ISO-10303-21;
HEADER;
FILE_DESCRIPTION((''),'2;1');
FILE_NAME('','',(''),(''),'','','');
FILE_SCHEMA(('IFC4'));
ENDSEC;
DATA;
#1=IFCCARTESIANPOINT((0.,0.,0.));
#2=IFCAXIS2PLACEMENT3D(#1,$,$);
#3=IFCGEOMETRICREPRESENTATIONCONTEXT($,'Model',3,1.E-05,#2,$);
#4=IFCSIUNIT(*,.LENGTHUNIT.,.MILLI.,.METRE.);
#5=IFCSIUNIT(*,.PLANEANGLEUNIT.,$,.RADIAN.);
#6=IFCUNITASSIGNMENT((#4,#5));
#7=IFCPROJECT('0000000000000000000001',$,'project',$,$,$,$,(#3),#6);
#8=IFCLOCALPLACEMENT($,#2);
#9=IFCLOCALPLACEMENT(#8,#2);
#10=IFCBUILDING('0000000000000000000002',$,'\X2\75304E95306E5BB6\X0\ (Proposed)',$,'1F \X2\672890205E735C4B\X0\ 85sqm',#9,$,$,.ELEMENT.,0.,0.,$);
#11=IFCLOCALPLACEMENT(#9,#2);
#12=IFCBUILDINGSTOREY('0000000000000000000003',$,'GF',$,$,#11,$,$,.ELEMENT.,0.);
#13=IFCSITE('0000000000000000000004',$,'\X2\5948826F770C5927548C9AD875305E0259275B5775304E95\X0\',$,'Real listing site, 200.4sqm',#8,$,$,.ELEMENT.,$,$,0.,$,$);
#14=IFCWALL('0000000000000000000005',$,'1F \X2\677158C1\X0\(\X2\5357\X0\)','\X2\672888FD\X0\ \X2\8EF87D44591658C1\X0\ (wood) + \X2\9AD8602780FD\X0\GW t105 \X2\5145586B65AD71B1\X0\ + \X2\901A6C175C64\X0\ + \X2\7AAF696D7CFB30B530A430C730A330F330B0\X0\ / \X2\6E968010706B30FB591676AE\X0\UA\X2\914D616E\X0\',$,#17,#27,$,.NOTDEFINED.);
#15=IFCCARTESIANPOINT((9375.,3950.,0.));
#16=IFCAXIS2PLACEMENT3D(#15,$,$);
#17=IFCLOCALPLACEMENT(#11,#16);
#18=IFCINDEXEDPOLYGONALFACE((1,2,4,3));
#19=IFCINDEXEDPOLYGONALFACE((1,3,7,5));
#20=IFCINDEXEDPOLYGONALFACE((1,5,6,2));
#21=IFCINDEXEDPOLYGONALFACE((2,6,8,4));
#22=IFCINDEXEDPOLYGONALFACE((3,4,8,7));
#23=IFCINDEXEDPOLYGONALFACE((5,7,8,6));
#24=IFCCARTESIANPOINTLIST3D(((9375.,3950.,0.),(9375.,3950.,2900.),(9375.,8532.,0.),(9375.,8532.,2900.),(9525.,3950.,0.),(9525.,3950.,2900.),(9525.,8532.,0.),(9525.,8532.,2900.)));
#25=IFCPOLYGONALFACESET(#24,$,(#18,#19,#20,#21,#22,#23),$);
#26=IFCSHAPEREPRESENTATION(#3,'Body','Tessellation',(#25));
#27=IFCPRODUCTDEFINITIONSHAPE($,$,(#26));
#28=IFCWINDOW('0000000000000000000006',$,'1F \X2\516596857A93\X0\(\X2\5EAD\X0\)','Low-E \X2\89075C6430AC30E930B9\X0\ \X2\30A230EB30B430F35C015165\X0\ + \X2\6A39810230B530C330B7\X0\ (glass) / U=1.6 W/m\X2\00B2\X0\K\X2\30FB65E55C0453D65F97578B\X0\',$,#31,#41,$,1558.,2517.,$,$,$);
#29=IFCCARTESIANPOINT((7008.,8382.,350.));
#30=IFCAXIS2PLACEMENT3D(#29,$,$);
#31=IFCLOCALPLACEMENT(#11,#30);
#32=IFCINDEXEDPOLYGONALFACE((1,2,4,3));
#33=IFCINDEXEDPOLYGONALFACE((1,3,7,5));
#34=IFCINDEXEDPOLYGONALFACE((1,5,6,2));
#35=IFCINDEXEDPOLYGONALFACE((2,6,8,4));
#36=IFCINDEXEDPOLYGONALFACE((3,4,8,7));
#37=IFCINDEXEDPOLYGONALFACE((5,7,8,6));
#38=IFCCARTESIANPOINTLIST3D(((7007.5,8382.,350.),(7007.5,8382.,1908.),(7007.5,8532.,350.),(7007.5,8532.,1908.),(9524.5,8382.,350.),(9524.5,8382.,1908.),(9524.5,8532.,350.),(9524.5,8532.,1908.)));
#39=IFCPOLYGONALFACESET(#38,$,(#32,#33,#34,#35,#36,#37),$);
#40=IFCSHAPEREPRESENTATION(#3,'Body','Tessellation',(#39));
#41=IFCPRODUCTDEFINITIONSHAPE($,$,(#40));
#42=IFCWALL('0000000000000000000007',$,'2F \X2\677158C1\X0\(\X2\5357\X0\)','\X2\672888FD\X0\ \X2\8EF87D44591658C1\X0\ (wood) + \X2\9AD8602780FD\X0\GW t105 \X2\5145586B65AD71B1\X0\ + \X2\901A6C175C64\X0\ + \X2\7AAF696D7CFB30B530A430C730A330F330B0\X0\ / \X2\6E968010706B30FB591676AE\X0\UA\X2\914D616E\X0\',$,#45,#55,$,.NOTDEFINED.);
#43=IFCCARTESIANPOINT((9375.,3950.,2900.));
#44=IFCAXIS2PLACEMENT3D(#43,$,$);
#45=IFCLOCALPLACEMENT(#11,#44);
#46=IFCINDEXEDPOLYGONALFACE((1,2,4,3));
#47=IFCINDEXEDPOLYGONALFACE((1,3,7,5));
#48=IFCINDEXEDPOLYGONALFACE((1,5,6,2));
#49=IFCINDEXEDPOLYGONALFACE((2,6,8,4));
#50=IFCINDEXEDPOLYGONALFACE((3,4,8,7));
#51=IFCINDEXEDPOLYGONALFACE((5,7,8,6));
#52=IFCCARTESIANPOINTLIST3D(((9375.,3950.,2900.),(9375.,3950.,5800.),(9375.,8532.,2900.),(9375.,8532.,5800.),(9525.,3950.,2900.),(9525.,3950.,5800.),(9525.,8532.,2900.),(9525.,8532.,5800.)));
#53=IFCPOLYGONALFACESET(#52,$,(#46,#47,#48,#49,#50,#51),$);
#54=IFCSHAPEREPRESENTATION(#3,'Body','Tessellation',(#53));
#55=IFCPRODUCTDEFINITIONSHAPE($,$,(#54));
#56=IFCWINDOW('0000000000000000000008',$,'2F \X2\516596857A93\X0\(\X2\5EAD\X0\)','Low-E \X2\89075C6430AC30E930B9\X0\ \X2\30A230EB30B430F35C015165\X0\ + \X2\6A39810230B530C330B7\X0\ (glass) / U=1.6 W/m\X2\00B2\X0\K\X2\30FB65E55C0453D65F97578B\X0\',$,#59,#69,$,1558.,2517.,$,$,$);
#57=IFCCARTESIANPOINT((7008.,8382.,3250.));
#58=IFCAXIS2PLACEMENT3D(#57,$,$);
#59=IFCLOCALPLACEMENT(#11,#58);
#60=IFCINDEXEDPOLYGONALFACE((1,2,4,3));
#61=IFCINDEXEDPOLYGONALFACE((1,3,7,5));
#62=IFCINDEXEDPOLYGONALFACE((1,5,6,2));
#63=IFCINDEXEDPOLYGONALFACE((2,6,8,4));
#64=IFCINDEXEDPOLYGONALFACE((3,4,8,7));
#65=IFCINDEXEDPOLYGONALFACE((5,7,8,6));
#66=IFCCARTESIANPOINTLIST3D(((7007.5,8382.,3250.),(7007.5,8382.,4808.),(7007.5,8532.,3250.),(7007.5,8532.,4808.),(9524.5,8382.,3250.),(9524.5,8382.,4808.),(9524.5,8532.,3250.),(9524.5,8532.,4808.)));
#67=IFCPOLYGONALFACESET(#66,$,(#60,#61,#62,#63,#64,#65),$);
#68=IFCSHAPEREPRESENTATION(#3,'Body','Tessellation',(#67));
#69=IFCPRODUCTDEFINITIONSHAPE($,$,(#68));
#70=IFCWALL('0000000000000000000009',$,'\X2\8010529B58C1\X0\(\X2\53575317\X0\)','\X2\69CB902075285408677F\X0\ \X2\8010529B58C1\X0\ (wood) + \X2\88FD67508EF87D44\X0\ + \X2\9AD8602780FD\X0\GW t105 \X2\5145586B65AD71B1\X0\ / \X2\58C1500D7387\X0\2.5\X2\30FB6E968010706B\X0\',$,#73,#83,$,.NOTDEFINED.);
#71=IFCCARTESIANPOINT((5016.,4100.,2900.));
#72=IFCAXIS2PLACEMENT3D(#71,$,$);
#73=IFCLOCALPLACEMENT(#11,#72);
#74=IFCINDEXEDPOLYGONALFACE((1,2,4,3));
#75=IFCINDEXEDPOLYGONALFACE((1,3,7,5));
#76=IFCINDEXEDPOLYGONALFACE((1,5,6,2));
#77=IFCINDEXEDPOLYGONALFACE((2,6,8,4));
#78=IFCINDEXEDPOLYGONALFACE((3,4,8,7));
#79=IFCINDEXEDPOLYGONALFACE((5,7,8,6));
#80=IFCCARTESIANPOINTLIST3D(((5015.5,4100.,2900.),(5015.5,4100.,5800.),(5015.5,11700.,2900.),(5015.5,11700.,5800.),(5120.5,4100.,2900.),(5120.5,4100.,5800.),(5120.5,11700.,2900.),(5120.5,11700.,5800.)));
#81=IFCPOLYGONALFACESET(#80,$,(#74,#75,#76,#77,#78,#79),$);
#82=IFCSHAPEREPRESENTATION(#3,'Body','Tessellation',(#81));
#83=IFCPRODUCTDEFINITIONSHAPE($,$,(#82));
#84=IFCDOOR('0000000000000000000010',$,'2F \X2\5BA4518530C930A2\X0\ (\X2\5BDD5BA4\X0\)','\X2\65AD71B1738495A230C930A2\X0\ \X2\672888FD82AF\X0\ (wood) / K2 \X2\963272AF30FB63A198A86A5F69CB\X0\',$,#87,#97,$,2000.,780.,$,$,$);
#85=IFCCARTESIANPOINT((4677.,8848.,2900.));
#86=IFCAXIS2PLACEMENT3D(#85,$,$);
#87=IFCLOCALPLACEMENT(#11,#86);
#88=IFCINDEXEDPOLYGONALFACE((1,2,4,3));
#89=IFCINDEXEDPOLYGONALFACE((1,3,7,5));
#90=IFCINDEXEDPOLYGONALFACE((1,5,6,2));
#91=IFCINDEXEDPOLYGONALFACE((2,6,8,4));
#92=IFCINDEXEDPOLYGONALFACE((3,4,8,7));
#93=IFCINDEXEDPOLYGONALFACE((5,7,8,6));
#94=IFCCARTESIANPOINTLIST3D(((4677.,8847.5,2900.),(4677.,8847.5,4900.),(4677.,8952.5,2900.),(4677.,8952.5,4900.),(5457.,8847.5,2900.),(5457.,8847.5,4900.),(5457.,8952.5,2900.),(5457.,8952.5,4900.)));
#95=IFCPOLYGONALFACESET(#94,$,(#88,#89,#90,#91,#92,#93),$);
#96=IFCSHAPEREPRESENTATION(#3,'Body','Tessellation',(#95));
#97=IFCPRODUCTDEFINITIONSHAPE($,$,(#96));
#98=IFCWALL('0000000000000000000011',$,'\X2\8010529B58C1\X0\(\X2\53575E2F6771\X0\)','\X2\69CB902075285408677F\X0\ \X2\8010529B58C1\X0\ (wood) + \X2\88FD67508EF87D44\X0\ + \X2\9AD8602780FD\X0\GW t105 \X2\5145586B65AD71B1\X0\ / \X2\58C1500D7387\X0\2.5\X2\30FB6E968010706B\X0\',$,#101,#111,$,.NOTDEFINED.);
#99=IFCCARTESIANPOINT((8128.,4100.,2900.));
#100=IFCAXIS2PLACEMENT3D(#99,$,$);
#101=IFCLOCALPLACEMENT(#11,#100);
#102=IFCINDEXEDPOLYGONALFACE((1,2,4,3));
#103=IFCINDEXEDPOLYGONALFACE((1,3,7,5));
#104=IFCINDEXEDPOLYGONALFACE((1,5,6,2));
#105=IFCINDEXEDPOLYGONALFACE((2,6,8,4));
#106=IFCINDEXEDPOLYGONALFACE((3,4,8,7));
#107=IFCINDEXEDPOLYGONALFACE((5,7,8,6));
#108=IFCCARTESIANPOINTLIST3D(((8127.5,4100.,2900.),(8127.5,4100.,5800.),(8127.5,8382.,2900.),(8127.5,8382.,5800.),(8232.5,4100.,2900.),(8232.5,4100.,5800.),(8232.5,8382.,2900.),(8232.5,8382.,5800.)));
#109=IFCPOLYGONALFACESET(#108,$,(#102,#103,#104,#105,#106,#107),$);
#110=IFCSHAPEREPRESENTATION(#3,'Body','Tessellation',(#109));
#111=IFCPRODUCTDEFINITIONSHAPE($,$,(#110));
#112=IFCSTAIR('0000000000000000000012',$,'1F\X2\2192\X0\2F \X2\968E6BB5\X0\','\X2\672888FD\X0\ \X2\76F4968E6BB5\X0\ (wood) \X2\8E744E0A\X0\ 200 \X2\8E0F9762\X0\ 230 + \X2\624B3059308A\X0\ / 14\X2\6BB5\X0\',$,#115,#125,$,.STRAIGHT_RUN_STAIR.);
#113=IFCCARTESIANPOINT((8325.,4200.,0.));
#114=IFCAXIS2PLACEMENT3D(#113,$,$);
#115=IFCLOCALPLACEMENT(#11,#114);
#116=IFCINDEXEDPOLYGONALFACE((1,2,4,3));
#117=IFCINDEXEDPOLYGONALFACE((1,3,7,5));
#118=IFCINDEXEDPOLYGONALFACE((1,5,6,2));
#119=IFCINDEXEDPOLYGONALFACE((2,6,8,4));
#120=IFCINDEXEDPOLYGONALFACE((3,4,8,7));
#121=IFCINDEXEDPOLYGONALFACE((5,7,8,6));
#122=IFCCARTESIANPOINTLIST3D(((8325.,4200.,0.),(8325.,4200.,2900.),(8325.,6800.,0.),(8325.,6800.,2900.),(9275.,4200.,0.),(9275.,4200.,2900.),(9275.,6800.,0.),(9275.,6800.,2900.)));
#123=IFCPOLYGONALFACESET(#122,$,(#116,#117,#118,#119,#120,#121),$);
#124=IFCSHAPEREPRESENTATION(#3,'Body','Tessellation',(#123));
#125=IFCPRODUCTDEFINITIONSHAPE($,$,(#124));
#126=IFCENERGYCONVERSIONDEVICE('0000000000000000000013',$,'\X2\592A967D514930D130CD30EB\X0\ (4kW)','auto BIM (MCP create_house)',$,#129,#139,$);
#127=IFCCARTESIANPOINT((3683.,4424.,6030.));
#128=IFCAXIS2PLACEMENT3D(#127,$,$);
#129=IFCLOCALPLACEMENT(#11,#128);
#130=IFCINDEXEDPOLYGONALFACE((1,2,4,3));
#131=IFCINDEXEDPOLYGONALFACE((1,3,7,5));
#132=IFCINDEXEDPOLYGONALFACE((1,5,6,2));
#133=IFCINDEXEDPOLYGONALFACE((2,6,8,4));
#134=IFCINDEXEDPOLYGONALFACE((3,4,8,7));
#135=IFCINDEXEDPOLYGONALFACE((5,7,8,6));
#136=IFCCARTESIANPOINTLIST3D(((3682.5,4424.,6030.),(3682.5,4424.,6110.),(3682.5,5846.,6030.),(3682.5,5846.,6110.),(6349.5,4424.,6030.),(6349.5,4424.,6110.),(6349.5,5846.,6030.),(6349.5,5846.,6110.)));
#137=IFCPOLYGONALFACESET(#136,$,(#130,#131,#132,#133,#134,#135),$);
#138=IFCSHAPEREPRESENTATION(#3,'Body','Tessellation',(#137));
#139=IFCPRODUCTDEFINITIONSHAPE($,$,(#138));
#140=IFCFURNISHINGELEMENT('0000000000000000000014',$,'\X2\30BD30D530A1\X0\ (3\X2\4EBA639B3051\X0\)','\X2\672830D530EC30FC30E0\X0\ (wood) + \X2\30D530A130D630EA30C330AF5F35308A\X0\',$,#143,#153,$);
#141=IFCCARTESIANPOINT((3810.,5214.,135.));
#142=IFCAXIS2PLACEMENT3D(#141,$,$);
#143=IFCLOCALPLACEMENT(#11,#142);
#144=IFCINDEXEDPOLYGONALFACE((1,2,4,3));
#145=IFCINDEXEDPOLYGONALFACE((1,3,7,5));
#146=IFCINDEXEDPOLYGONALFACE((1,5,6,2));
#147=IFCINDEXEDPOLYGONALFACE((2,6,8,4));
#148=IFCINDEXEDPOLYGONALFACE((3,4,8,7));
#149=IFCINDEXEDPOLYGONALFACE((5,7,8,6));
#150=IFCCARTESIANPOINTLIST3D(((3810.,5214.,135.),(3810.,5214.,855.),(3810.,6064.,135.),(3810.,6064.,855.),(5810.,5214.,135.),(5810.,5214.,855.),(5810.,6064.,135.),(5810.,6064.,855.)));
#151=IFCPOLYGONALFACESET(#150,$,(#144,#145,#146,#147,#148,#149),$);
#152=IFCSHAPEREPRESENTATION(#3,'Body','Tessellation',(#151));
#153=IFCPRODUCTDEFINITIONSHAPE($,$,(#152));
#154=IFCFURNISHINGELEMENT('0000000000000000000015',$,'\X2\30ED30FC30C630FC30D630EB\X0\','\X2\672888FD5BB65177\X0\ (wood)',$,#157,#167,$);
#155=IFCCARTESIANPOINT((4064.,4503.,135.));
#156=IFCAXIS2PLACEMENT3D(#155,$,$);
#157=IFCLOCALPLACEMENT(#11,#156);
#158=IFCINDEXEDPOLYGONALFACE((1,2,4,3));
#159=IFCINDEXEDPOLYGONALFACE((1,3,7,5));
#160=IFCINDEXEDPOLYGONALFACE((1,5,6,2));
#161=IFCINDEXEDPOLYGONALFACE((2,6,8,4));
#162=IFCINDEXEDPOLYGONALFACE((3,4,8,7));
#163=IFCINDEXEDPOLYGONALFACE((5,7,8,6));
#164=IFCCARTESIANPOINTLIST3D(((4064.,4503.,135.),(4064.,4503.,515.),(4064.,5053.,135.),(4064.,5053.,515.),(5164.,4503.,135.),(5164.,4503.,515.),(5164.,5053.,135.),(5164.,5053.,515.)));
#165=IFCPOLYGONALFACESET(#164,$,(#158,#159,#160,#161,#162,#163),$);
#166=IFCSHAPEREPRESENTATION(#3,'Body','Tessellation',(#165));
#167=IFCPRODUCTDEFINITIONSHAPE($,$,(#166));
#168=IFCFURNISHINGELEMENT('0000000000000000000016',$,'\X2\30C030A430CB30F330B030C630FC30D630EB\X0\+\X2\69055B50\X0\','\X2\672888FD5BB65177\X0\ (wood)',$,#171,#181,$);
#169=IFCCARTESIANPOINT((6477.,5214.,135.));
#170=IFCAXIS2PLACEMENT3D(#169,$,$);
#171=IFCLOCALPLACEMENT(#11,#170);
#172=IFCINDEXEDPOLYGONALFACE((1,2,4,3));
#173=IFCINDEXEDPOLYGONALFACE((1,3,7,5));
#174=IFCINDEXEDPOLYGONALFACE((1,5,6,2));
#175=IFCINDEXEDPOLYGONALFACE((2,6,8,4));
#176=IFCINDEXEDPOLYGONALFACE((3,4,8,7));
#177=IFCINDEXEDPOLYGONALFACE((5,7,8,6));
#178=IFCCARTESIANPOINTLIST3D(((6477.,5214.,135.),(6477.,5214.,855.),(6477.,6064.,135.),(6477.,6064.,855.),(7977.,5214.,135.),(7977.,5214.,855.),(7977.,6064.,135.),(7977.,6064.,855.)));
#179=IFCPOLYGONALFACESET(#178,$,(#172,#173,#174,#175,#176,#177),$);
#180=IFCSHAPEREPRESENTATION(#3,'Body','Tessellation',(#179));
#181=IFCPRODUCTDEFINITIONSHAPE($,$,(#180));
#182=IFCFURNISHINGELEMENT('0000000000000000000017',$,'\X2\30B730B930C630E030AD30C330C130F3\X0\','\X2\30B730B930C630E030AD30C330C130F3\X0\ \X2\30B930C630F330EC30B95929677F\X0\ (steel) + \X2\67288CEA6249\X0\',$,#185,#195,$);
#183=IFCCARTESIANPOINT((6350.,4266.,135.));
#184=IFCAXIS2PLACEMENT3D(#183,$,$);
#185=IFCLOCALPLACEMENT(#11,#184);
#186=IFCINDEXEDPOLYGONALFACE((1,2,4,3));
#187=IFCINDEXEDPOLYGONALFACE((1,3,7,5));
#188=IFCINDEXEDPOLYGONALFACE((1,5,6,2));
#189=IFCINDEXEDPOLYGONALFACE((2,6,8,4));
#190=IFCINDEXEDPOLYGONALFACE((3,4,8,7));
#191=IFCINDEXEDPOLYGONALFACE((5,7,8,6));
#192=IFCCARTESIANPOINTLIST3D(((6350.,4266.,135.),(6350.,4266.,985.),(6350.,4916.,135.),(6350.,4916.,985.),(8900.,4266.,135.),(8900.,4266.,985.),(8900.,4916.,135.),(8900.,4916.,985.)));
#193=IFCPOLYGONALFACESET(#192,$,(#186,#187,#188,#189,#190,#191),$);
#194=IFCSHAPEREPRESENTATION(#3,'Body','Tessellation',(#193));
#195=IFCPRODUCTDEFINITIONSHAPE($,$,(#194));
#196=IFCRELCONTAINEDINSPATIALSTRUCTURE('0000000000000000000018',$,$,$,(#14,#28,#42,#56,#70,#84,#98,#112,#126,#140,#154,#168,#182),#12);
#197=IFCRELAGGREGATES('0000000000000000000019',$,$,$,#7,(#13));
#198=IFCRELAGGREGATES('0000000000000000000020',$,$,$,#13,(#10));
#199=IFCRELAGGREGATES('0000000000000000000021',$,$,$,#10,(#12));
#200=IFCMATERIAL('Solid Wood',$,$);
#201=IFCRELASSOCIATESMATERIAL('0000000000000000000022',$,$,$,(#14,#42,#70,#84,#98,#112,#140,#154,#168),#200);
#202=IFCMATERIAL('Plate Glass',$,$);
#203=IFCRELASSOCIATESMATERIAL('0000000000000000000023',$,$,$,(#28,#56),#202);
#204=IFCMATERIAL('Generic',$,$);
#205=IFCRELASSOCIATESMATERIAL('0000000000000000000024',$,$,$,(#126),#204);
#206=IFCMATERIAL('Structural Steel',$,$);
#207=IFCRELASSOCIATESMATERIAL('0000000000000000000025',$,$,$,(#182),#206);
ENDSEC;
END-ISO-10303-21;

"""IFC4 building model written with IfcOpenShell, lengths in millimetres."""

from ifc_helpers import new_model, si_unit, frame, frame_2d, origin, place, context, project, spatial, rectangle, extrude, material, element, fill, save


model = new_model("IFC4")

# Units and contexts
model_context = context("Model", 3, precision=1e-05, world=origin())
ifc_project = project(units=[si_unit("LENGTHUNIT", "METRE", prefix="MILLI"), si_unit("PLANEANGLEUNIT", "RADIAN")], contexts=[model_context])

# Site, building, storey
site_placement = place(None, origin())
site = spatial("IfcSite", under=ifc_project, at=site_placement, Name="奈良県大和高田市大字田井", ObjectType="Real listing site, 200.4sqm", CompositionType="ELEMENT", RefElevation=0.0)
building_placement = place(site_placement, origin())
building = spatial("IfcBuilding", under=site, at=building_placement, Name="田井の家 (Proposed)", ObjectType="1F 木造平屋 85sqm", CompositionType="ELEMENT", ElevationOfRefHeight=0.0, ElevationOfTerrain=0.0)
storey_placement = place(building_placement, origin())
storey = spatial("IfcBuildingStorey", under=building, at=storey_placement, Name="GF", CompositionType="ELEMENT", Elevation=0.0)

# Wall, opening, window
ifc_material_1 = material(Name="Solid Wood")
wall_1_placement = place(storey_placement, frame((9375.0, 3950.0, 0.0)))
wall_1 = element("IfcWall", 1, at=wall_1_placement, inside=storey, material=ifc_material_1, Name="1F 東壁(南)", Description="木製 軸組外壁 (wood) + 高性能GW t105 充填断熱 + 通気層 + 窯業系サイディング / 準耐火・外皮UA配慮", PredefinedType="NOTDEFINED", context=model_context, shape_type="SweptSolid", body=[
    extrude(rectangle(XDim=150.0, YDim=4582.0, at=frame_2d((75.0, 2291.0))), frame((9375.0, 3950.0, 0.0)), (0.0, 0.0, 1.0), 2900.0),
])
opening_1_placement = place(storey_placement, frame((7008.0, 8382.0, 350.0)))
opening_1 = element("IfcOpeningElement", 2, at=opening_1_placement, cuts=wall_1, PredefinedType="NOTDEFINED", context=model_context, shape_type="SweptSolid", body=[
    extrude(rectangle(XDim=2517.0, YDim=150.0, at=frame_2d((1258.0, 75.0))), frame((7008.0, 8382.0, 350.0)), (0.0, 0.0, 1.0), 1558.0),
])
ifc_material_2 = material(Name="Plate Glass")
window_1_placement = place(storey_placement, frame((7008.0, 8382.0, 350.0)))
window_1 = element("IfcWindow", 3, at=window_1_placement, inside=storey, material=ifc_material_2, Name="1F 入隅窓(庭)", Description="Low-E 複層ガラス アルゴン封入 + 樹脂サッシ (glass) / U=1.6 W/m²K・日射取得型", OverallHeight=1558.0, OverallWidth=2517.0, context=model_context, shape_type="SweptSolid", body=[
    extrude(rectangle(XDim=2517.0, YDim=150.0, at=frame_2d((1258.0, 75.0))), frame((7008.0, 8382.0, 350.0)), (0.0, 0.0, 1.0), 1558.0),
])
fill(opening_1, window_1)

# Wall, opening, window
wall_2_placement = place(storey_placement, frame((9375.0, 3950.0, 2900.0)))
wall_2 = element("IfcWall", 4, at=wall_2_placement, inside=storey, material=ifc_material_1, Name="2F 東壁(南)", Description="木製 軸組外壁 (wood) + 高性能GW t105 充填断熱 + 通気層 + 窯業系サイディング / 準耐火・外皮UA配慮", PredefinedType="NOTDEFINED", context=model_context, shape_type="SweptSolid", body=[
    extrude(rectangle(XDim=150.0, YDim=4582.0, at=frame_2d((75.0, 2291.0))), frame((9375.0, 3950.0, 2900.0)), (0.0, 0.0, 1.0), 2900.0),
])
opening_2_placement = place(storey_placement, frame((7008.0, 8382.0, 3250.0)))
opening_2 = element("IfcOpeningElement", 5, at=opening_2_placement, cuts=wall_2, PredefinedType="NOTDEFINED", context=model_context, shape_type="SweptSolid", body=[
    extrude(rectangle(XDim=2517.0, YDim=150.0, at=frame_2d((1258.0, 75.0))), frame((7008.0, 8382.0, 3250.0)), (0.0, 0.0, 1.0), 1558.0),
])
window_2_placement = place(storey_placement, frame((7008.0, 8382.0, 3250.0)))
window_2 = element("IfcWindow", 6, at=window_2_placement, inside=storey, material=ifc_material_2, Name="2F 入隅窓(庭)", Description="Low-E 複層ガラス アルゴン封入 + 樹脂サッシ (glass) / U=1.6 W/m²K・日射取得型", OverallHeight=1558.0, OverallWidth=2517.0, context=model_context, shape_type="SweptSolid", body=[
    extrude(rectangle(XDim=2517.0, YDim=150.0, at=frame_2d((1258.0, 75.0))), frame((7008.0, 8382.0, 3250.0)), (0.0, 0.0, 1.0), 1558.0),
])
fill(opening_2, window_2)

# Wall, opening, door
wall_3_placement = place(storey_placement, frame((5016.0, 4100.0, 2900.0)))
wall_3 = element("IfcWall", 7, at=wall_3_placement, inside=storey, material=ifc_material_1, Name="耐力壁(南北)", Description="構造用合板 耐力壁 (wood) + 製材軸組 + 高性能GW t105 充填断熱 / 壁倍率2.5・準耐火", PredefinedType="NOTDEFINED", context=model_context, shape_type="SweptSolid", body=[
    extrude(rectangle(XDim=105.0, YDim=7600.0, at=frame_2d((52.0, 3800.0))), frame((5016.0, 4100.0, 2900.0)), (0.0, 0.0, 1.0), 2900.0),
])
opening_3_placement = place(storey_placement, frame((4677.0, 8848.0, 2900.0)))
opening_3 = element("IfcOpeningElement", 8, at=opening_3_placement, cuts=wall_3, PredefinedType="NOTDEFINED", context=model_context, shape_type="SweptSolid", body=[
    extrude(rectangle(XDim=780.0, YDim=105.0, at=frame_2d((390.0, 52.0))), frame((4677.0, 8848.0, 2900.0)), (0.0, 0.0, 1.0), 2000.0),
])
door_1_placement = place(storey_placement, frame((4677.0, 8848.0, 2900.0)))
door_1 = element("IfcDoor", 9, at=door_1_placement, inside=storey, material=ifc_material_1, Name="2F 室内ドア (寝室)", Description="断熱玄関ドア 木製芯 (wood) / K2 防犯・採風機構", OverallHeight=2000.0, OverallWidth=780.0, context=model_context, shape_type="SweptSolid", body=[
    extrude(rectangle(XDim=780.0, YDim=105.0, at=frame_2d((390.0, 52.0))), frame((4677.0, 8848.0, 2900.0)), (0.0, 0.0, 1.0), 2000.0),
])
fill(opening_3, door_1)

# Wall
wall_4_placement = place(storey_placement, frame((8128.0, 4100.0, 2900.0)))
element("IfcWall", 10, at=wall_4_placement, inside=storey, material=ifc_material_1, Name="耐力壁(南帯東)", Description="構造用合板 耐力壁 (wood) + 製材軸組 + 高性能GW t105 充填断熱 / 壁倍率2.5・準耐火", PredefinedType="NOTDEFINED", context=model_context, shape_type="SweptSolid", body=[
    extrude(rectangle(XDim=105.0, YDim=4282.0, at=frame_2d((52.0, 2141.0))), frame((8128.0, 4100.0, 2900.0)), (0.0, 0.0, 1.0), 2900.0),
])

# Stair
stair_placement = place(storey_placement, frame((8325.0, 4200.0, 0.0)))
element("IfcStair", 11, at=stair_placement, inside=storey, material=ifc_material_1, Name="1F→2F 階段", Description="木製 直階段 (wood) 蹴上 200 踏面 230 + 手すり / 14段", PredefinedType="STRAIGHT_RUN_STAIR", context=model_context, shape_type="SweptSolid", body=[
    extrude(rectangle(XDim=950.0, YDim=2600.0, at=frame_2d((475.0, 1300.0))), frame((8325.0, 4200.0, 0.0)), (0.0, 0.0, 1.0), 2900.0),
])

# Energy conversion device
ifc_material_3 = material(Name="Generic")
energy_conversion_device_placement = place(storey_placement, frame((3683.0, 4424.0, 6030.0)))
element("IfcEnergyConversionDevice", 12, at=energy_conversion_device_placement, inside=storey, material=ifc_material_3, Name="太陽光パネル (4kW)", Description="auto BIM (MCP create_house)", context=model_context, shape_type="SweptSolid", body=[
    extrude(rectangle(XDim=2667.0, YDim=1422.0, at=frame_2d((1333.0, 711.0))), frame((3683.0, 4424.0, 6030.0)), (0.0, 0.0, 1.0), 80.0),
])

# Furnishing elements
furnishing_1_placement = place(storey_placement, frame((3810.0, 5214.0, 135.0)))
element("IfcFurnishingElement", 13, at=furnishing_1_placement, inside=storey, material=ifc_material_1, Name="ソファ (3人掛け)", Description="木フレーム (wood) + ファブリック張り", context=model_context, shape_type="SweptSolid", body=[
    extrude(rectangle(XDim=2000.0, YDim=850.0, at=frame_2d((1000.0, 425.0))), frame((3810.0, 5214.0, 135.0)), (0.0, 0.0, 1.0), 720.0),
])
furnishing_2_placement = place(storey_placement, frame((4064.0, 4503.0, 135.0)))
element("IfcFurnishingElement", 14, at=furnishing_2_placement, inside=storey, material=ifc_material_1, Name="ローテーブル", Description="木製家具 (wood)", context=model_context, shape_type="SweptSolid", body=[
    extrude(rectangle(XDim=1100.0, YDim=550.0, at=frame_2d((550.0, 275.0))), frame((4064.0, 4503.0, 135.0)), (0.0, 0.0, 1.0), 380.0),
])
furnishing_3_placement = place(storey_placement, frame((6477.0, 5214.0, 135.0)))
element("IfcFurnishingElement", 15, at=furnishing_3_placement, inside=storey, material=ifc_material_1, Name="ダイニングテーブル+椅子", Description="木製家具 (wood)", context=model_context, shape_type="SweptSolid", body=[
    extrude(rectangle(XDim=1500.0, YDim=850.0, at=frame_2d((750.0, 425.0))), frame((6477.0, 5214.0, 135.0)), (0.0, 0.0, 1.0), 720.0),
])
ifc_material_4 = material(Name="Structural Steel")
furnishing_4_placement = place(storey_placement, frame((6350.0, 4266.0, 135.0)))
element("IfcFurnishingElement", 16, at=furnishing_4_placement, inside=storey, material=ifc_material_4, Name="システムキッチン", Description="システムキッチン ステンレス天板 (steel) + 木質扉", context=model_context, shape_type="SweptSolid", body=[
    extrude(rectangle(XDim=2550.0, YDim=650.0, at=frame_2d((1275.0, 325.0))), frame((6350.0, 4266.0, 135.0)), (0.0, 0.0, 1.0), 850.0),
])

save(model, "model.ifc")
